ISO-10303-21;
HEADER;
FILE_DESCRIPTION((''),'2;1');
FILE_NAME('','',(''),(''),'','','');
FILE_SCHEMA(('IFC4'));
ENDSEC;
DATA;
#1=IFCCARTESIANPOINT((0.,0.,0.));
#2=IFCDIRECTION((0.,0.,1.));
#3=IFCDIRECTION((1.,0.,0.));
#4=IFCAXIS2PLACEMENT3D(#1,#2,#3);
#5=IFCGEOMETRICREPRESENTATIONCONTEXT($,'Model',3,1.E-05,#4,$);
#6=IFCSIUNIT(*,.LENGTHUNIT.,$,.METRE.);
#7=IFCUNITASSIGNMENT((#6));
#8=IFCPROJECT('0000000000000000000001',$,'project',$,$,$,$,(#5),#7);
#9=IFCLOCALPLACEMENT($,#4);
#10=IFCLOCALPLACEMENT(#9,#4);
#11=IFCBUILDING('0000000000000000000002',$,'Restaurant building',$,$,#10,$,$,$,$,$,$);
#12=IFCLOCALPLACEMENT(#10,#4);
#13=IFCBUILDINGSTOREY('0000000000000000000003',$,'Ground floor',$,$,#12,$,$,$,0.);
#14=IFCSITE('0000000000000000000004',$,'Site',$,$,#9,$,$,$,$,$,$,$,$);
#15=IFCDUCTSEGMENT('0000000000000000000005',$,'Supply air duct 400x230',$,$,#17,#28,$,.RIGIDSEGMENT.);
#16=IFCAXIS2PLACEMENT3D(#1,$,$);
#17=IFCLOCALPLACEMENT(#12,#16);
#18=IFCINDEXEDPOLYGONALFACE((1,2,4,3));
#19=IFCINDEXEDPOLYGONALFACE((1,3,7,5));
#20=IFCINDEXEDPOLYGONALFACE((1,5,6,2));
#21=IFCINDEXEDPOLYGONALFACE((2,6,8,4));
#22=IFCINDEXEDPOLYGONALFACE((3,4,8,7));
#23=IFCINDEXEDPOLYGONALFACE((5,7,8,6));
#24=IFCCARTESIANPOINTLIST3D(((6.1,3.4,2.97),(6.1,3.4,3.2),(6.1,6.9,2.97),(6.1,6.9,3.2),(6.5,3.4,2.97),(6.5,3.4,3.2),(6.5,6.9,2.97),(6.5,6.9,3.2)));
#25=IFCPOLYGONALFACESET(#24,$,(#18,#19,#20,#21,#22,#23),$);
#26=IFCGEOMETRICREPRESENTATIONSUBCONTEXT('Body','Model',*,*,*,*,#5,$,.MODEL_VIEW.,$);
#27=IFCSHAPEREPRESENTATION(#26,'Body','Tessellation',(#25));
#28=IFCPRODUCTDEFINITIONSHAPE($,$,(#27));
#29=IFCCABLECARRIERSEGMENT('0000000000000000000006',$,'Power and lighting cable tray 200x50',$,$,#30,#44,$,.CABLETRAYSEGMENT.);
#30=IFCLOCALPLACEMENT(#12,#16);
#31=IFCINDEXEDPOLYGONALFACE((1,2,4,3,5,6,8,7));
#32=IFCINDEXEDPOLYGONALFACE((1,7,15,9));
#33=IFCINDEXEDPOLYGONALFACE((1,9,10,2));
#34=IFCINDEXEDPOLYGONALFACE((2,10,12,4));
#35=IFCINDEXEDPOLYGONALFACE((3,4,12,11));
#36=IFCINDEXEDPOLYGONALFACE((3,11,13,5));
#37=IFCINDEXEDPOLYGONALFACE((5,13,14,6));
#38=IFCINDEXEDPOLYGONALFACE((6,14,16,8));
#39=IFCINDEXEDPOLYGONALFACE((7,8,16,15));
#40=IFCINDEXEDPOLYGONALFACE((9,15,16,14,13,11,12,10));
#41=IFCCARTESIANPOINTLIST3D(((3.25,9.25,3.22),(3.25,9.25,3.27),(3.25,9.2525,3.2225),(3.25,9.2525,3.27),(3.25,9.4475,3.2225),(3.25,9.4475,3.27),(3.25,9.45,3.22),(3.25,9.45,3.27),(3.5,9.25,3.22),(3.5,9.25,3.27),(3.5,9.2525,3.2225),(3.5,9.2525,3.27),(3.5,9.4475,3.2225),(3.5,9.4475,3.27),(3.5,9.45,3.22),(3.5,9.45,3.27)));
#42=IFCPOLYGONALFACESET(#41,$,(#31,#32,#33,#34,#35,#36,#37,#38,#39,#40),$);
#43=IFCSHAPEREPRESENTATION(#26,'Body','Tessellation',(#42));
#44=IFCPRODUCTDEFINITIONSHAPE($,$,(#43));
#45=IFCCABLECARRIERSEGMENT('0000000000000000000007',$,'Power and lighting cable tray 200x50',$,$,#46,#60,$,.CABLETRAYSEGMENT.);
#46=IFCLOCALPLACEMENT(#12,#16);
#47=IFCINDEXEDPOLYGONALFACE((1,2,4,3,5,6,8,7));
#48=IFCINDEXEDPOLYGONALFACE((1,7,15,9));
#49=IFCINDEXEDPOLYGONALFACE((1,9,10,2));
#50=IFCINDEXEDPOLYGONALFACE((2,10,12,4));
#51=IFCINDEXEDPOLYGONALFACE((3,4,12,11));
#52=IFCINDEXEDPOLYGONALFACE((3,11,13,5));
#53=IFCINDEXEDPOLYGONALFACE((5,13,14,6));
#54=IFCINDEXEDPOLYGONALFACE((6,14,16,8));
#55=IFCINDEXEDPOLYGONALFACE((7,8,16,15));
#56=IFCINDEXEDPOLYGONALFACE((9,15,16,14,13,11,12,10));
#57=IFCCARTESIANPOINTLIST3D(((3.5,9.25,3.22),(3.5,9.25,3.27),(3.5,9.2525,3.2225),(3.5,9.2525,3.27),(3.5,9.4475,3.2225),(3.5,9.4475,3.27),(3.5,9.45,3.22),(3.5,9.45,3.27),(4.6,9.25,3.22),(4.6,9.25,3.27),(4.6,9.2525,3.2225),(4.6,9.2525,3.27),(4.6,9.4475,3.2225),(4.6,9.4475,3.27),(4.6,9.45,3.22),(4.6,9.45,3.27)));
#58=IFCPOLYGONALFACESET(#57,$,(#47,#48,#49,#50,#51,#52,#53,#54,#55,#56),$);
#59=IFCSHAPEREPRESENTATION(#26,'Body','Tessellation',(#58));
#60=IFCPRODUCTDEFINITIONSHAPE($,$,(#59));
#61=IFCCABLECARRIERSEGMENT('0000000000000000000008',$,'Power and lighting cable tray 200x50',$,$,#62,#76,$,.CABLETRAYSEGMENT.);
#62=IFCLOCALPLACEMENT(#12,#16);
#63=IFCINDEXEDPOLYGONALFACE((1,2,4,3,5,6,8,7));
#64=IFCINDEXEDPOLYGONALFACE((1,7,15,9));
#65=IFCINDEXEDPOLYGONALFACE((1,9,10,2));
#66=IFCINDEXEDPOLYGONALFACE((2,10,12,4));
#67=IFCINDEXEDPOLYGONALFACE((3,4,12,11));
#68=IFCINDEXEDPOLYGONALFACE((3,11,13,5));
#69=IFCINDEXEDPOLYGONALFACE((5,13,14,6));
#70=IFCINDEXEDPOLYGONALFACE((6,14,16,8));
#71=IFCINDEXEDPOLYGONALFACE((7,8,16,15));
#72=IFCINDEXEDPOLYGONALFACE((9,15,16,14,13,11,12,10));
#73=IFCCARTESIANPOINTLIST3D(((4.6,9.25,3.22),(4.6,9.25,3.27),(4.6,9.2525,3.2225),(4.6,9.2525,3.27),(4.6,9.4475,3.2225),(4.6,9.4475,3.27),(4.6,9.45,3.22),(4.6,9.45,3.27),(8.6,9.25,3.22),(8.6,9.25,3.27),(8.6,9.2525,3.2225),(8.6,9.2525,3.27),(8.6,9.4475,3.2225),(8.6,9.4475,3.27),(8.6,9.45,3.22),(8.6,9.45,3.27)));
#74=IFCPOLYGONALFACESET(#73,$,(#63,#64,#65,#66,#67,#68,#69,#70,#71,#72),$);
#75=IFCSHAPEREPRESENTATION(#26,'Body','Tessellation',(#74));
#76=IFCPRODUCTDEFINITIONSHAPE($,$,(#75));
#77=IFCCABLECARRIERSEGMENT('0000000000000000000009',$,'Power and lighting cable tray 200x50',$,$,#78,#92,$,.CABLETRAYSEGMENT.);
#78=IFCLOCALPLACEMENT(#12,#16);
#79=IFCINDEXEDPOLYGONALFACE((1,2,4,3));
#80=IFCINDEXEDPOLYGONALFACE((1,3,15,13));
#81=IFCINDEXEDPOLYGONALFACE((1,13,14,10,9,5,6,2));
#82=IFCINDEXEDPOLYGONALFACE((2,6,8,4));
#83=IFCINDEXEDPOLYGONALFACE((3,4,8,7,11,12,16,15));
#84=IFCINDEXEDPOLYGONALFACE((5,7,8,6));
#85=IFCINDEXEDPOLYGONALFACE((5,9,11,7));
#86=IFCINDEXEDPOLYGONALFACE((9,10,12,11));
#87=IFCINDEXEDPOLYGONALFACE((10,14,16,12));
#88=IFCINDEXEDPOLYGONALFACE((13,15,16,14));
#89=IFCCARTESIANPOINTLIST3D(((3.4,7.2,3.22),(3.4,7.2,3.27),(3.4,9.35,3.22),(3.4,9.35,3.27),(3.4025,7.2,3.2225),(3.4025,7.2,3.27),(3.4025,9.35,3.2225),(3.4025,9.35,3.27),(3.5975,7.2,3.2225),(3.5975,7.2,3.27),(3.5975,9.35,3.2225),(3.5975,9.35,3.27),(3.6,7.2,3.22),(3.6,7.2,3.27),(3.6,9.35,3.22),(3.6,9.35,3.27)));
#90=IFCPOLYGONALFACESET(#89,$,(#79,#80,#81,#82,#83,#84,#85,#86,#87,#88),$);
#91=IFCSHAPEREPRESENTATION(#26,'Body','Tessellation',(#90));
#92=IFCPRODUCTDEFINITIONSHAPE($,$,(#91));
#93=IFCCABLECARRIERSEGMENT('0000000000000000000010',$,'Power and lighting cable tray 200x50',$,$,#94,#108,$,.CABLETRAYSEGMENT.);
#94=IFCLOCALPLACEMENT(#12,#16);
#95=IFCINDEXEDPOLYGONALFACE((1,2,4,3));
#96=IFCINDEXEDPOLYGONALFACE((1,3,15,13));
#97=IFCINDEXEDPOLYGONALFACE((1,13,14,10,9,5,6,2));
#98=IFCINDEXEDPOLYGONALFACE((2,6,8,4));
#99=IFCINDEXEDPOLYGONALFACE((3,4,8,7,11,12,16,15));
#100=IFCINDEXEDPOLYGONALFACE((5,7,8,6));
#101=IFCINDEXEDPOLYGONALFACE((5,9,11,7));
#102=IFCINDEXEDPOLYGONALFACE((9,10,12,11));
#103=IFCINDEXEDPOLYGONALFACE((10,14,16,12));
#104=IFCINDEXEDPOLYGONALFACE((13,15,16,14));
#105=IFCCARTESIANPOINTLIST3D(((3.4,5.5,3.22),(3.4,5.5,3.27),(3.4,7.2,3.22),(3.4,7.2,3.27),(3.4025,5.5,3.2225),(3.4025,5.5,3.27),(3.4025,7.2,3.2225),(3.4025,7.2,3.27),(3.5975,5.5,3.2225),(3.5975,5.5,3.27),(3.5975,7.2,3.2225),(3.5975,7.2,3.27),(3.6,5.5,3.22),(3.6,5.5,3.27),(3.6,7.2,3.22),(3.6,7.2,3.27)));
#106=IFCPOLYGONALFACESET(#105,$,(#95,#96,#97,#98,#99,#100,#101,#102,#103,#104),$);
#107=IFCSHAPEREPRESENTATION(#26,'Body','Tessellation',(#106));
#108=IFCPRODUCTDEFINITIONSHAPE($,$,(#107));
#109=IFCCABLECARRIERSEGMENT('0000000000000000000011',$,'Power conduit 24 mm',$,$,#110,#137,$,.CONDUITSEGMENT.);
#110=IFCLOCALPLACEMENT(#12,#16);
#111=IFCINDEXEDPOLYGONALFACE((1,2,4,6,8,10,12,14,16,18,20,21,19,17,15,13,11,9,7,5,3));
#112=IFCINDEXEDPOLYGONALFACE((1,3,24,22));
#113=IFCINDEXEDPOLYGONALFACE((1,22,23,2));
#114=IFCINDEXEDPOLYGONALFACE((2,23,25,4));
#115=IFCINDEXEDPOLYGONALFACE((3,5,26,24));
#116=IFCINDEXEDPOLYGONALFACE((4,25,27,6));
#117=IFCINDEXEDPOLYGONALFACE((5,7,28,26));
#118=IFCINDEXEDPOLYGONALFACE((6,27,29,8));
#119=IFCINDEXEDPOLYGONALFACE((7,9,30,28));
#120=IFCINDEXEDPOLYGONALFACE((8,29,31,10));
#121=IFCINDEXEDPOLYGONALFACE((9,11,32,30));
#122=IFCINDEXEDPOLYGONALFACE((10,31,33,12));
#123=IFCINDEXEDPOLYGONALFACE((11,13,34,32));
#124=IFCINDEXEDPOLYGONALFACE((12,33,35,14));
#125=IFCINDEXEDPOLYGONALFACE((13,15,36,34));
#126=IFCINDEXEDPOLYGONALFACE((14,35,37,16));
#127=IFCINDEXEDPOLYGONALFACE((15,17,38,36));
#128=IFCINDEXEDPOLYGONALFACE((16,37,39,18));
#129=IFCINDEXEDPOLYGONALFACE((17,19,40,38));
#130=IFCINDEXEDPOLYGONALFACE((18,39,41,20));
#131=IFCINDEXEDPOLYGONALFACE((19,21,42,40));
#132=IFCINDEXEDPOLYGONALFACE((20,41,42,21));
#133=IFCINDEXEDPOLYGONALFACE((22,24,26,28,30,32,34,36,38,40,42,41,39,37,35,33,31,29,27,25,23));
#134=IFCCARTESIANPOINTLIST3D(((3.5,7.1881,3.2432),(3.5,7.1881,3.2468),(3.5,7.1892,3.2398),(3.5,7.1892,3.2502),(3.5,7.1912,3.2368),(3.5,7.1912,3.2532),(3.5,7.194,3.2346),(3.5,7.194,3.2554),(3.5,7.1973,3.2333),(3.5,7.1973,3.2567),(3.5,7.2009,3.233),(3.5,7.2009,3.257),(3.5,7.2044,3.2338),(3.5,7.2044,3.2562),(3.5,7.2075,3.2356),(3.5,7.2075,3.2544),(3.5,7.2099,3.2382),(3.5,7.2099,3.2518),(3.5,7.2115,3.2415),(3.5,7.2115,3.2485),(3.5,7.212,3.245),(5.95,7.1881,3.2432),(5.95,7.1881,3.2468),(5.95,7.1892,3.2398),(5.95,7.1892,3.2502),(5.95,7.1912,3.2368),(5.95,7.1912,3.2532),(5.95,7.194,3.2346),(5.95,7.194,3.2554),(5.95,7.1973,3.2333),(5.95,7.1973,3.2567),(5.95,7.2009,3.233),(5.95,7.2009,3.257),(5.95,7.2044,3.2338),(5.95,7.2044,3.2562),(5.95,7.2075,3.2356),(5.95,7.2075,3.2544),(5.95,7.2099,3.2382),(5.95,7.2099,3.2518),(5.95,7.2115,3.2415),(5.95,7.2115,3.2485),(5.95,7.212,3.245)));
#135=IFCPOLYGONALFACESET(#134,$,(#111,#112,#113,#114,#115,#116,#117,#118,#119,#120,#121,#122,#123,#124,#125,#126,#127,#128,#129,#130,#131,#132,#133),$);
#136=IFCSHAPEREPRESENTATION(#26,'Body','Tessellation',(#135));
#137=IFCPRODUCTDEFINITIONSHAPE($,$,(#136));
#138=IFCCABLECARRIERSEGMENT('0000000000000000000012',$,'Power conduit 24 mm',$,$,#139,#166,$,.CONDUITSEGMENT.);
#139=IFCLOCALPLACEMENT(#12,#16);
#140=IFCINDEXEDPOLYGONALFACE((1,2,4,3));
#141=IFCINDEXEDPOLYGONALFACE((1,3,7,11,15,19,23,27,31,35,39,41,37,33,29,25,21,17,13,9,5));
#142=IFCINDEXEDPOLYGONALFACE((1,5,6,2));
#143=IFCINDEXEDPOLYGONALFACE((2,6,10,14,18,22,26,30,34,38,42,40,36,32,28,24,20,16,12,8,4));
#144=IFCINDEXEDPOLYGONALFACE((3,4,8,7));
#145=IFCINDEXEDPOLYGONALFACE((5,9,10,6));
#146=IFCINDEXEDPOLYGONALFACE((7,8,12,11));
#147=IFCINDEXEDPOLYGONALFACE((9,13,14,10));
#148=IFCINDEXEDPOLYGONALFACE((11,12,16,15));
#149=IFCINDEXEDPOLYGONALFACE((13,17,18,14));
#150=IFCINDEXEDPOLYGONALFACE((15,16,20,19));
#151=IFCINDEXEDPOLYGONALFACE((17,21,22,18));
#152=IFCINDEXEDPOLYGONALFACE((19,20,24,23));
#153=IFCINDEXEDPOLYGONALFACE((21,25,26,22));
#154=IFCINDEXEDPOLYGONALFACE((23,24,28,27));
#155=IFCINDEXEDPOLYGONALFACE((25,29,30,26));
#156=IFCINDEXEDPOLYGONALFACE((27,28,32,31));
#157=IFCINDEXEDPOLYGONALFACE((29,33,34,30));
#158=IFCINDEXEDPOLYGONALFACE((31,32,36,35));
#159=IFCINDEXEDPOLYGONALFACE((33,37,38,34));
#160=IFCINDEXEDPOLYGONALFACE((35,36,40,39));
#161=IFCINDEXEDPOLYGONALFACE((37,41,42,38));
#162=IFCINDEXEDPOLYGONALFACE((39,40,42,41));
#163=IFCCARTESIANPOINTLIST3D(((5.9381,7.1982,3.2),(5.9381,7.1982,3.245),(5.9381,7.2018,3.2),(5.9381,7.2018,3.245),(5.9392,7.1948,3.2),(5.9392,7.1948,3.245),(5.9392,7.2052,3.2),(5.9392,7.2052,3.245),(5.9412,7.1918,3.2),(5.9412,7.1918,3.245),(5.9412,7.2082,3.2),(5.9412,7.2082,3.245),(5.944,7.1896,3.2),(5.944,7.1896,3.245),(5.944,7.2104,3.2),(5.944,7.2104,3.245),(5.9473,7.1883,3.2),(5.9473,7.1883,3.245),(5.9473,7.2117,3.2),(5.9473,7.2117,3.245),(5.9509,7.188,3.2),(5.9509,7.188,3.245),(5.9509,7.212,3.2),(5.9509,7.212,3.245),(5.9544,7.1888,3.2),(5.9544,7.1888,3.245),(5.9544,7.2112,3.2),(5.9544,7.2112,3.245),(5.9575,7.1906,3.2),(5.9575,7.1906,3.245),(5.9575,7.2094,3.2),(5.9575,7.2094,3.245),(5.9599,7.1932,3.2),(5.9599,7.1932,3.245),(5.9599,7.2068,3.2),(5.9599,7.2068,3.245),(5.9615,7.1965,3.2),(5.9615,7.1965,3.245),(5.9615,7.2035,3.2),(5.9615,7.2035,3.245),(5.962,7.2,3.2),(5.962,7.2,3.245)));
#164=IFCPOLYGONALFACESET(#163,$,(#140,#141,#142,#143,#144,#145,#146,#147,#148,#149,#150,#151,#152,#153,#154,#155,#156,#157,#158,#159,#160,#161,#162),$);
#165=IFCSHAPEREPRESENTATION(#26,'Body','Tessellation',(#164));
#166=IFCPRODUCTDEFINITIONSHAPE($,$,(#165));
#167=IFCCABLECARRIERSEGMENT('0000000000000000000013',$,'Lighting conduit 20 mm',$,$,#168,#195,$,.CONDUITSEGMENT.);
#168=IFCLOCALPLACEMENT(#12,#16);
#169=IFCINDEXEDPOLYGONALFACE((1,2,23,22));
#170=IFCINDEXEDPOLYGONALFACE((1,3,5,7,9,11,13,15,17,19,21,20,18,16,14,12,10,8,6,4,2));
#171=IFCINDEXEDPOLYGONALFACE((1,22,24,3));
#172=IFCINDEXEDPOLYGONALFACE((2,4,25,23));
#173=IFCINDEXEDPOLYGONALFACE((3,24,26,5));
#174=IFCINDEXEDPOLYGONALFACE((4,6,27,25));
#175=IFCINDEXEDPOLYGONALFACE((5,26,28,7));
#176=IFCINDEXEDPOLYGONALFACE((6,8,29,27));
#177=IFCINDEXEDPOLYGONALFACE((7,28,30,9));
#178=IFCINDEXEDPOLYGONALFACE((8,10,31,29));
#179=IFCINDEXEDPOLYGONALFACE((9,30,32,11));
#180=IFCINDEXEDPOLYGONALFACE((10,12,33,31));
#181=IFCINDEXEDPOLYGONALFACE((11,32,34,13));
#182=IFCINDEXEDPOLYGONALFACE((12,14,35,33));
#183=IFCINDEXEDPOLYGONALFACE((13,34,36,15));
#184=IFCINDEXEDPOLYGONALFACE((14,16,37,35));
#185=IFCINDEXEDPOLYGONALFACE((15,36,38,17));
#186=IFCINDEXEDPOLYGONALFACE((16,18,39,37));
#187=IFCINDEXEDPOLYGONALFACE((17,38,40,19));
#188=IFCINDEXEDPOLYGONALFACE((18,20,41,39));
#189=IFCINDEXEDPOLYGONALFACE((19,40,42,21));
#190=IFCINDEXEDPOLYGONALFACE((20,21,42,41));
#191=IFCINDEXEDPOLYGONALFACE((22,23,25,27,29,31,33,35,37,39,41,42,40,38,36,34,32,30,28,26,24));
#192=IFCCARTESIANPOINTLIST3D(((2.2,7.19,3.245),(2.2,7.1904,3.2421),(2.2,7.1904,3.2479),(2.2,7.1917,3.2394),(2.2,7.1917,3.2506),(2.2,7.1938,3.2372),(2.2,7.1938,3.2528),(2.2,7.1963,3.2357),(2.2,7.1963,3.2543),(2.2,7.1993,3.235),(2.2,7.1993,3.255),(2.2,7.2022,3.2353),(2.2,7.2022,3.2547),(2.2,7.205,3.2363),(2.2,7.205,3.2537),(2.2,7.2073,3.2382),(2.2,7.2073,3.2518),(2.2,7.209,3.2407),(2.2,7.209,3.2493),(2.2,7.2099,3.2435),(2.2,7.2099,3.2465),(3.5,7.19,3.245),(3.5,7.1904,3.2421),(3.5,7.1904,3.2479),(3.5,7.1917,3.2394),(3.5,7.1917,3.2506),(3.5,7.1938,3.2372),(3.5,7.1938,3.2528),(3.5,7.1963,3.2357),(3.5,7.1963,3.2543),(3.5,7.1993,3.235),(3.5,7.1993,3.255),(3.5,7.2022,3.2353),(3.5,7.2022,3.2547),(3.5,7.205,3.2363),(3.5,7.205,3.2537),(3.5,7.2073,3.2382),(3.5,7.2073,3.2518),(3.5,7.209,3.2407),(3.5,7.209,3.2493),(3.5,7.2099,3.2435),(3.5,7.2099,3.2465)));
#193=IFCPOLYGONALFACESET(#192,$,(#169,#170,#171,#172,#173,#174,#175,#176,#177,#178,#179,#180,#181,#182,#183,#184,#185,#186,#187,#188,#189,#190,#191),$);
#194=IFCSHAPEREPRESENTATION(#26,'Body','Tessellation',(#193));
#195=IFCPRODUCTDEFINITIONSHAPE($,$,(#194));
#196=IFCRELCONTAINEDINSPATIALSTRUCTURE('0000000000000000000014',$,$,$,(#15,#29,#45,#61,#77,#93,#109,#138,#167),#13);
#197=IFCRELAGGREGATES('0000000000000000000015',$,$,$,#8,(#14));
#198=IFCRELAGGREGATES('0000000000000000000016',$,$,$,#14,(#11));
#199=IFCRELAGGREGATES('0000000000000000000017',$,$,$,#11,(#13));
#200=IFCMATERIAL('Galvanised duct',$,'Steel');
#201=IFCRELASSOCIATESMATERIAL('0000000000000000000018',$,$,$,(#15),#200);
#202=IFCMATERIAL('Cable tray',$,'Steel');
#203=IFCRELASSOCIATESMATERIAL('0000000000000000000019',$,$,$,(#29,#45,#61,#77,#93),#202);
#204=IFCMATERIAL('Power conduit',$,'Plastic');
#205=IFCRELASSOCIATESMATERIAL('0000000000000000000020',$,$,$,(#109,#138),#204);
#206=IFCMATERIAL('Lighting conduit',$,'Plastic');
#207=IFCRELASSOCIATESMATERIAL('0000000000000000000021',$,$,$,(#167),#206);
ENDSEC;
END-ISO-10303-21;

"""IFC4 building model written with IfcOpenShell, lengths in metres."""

from ifc_helpers import new_model, si_unit, frame, origin_with_axes, origin_2d, place, context, subcontext, project, spatial, polyline, rectangle, circle, outline, extrude, material, element, save


model = new_model("IFC4")

# Units and contexts
model_context = context("Model", 3, precision=1e-05, world=origin_with_axes())
body_context = subcontext(model_context, "Body", "Model", "MODEL_VIEW")
ifc_project = project(units=[si_unit("LENGTHUNIT", "METRE")], contexts=[model_context])

# Site, building, storey
site_placement = place(None, origin_with_axes())
site = spatial("IfcSite", under=ifc_project, at=site_placement, Name="Site")
building_placement = place(site_placement, origin_with_axes())
building = spatial("IfcBuilding", under=site, at=building_placement, Name="Restaurant building")
storey_placement = place(building_placement, origin_with_axes())
storey = spatial("IfcBuildingStorey", under=building, at=storey_placement, Name="Ground floor", Elevation=0.0)

# Duct segment
ifc_material_1 = material(Name="Galvanised duct", Category="Steel")
duct_segment_placement = place(storey_placement, frame((6.3, 6.9, 3.085)))
element("IfcDuctSegment", 1, at=duct_segment_placement, inside=storey, material=ifc_material_1, Name="Supply air duct 400x230", PredefinedType="RIGIDSEGMENT", context=body_context, shape_type="SweptSolid", body=[
    extrude(rectangle(XDim=0.4, YDim=0.23, at=origin_2d()), frame((0.0, 0.0, 0.0), z_axis=(0.0, -1.0, 0.0), x_axis=(1.0, 0.0, 0.0)), (0.0, 0.0, 1.0), 3.5),
])

# Cable carrier segments
ifc_material_2 = material(Name="Cable tray", Category="Steel")
cable_carrier_segment_1_placement = place(storey_placement, frame((3.25, 9.35, 3.245)))
element("IfcCableCarrierSegment", 2, at=cable_carrier_segment_1_placement, inside=storey, material=ifc_material_2, Name="Power and lighting cable tray 200x50", PredefinedType="CABLETRAYSEGMENT", context=body_context, shape_type="SweptSolid", body=[
    extrude(outline(polyline([(-0.1, -0.025), (0.1, -0.025), (0.1, 0.025), (0.0975, 0.025), (0.0975, -0.0225), (-0.0975, -0.0225), (-0.0975, 0.025), (-0.1, 0.025), (-0.1, -0.025)])), frame((0.0, 0.0, 0.0), z_axis=(1.0, 0.0, 0.0), x_axis=(0.0, 1.0, 0.0)), (0.0, 0.0, 1.0), 0.25),
])
cable_carrier_segment_2_placement = place(storey_placement, frame((3.5, 9.35, 3.245)))
element("IfcCableCarrierSegment", 3, at=cable_carrier_segment_2_placement, inside=storey, material=ifc_material_2, Name="Power and lighting cable tray 200x50", PredefinedType="CABLETRAYSEGMENT", context=body_context, shape_type="SweptSolid", body=[
    extrude(outline(polyline([(-0.1, -0.025), (0.1, -0.025), (0.1, 0.025), (0.0975, 0.025), (0.0975, -0.0225), (-0.0975, -0.0225), (-0.0975, 0.025), (-0.1, 0.025), (-0.1, -0.025)])), frame((0.0, 0.0, 0.0), z_axis=(1.0, 0.0, 0.0), x_axis=(0.0, 1.0, 0.0)), (0.0, 0.0, 1.0), 1.1),
])
cable_carrier_segment_3_placement = place(storey_placement, frame((4.6, 9.35, 3.245)))
element("IfcCableCarrierSegment", 4, at=cable_carrier_segment_3_placement, inside=storey, material=ifc_material_2, Name="Power and lighting cable tray 200x50", PredefinedType="CABLETRAYSEGMENT", context=body_context, shape_type="SweptSolid", body=[
    extrude(outline(polyline([(-0.1, -0.025), (0.1, -0.025), (0.1, 0.025), (0.0975, 0.025), (0.0975, -0.0225), (-0.0975, -0.0225), (-0.0975, 0.025), (-0.1, 0.025), (-0.1, -0.025)])), frame((0.0, 0.0, 0.0), z_axis=(1.0, 0.0, 0.0), x_axis=(0.0, 1.0, 0.0)), (0.0, 0.0, 1.0), 4.0),
])
cable_carrier_segment_4_placement = place(storey_placement, frame((3.5, 9.35, 3.245)))
element("IfcCableCarrierSegment", 5, at=cable_carrier_segment_4_placement, inside=storey, material=ifc_material_2, Name="Power and lighting cable tray 200x50", PredefinedType="CABLETRAYSEGMENT", context=body_context, shape_type="SweptSolid", body=[
    extrude(outline(polyline([(-0.1, -0.025), (0.1, -0.025), (0.1, 0.025), (0.0975, 0.025), (0.0975, -0.0225), (-0.0975, -0.0225), (-0.0975, 0.025), (-0.1, 0.025), (-0.1, -0.025)])), frame((0.0, 0.0, 0.0), z_axis=(0.0, -1.0, 0.0), x_axis=(1.0, 0.0, 0.0)), (0.0, 0.0, 1.0), 2.15),
])
cable_carrier_segment_5_placement = place(storey_placement, frame((3.5, 7.2, 3.245)))
element("IfcCableCarrierSegment", 6, at=cable_carrier_segment_5_placement, inside=storey, material=ifc_material_2, Name="Power and lighting cable tray 200x50", PredefinedType="CABLETRAYSEGMENT", context=body_context, shape_type="SweptSolid", body=[
    extrude(outline(polyline([(-0.1, -0.025), (0.1, -0.025), (0.1, 0.025), (0.0975, 0.025), (0.0975, -0.0225), (-0.0975, -0.0225), (-0.0975, 0.025), (-0.1, 0.025), (-0.1, -0.025)])), frame((0.0, 0.0, 0.0), z_axis=(0.0, -1.0, 0.0), x_axis=(1.0, 0.0, 0.0)), (0.0, 0.0, 1.0), 1.7),
])
ifc_material_3 = material(Name="Power conduit", Category="Plastic")
cable_carrier_segment_6_placement = place(storey_placement, frame((3.5, 7.2, 3.245)))
element("IfcCableCarrierSegment", 7, at=cable_carrier_segment_6_placement, inside=storey, material=ifc_material_3, Name="Power conduit 24 mm", PredefinedType="CONDUITSEGMENT", context=body_context, shape_type="SweptSolid", body=[
    extrude(circle(Radius=0.012, at=origin_2d()), frame((0.0, 0.0, 0.0), z_axis=(1.0, 0.0, 0.0), x_axis=(0.0, 1.0, 0.0)), (0.0, 0.0, 1.0), 2.45),
])
cable_carrier_segment_7_placement = place(storey_placement, frame((5.95, 7.2, 3.245)))
element("IfcCableCarrierSegment", 8, at=cable_carrier_segment_7_placement, inside=storey, material=ifc_material_3, Name="Power conduit 24 mm", PredefinedType="CONDUITSEGMENT", context=body_context, shape_type="SweptSolid", body=[
    extrude(circle(Radius=0.012, at=origin_2d()), frame((0.0, 0.0, 0.0), z_axis=(0.0, 0.0, -1.0), x_axis=(1.0, 0.0, 0.0)), (0.0, 0.0, 1.0), 0.045),
])
ifc_material_4 = material(Name="Lighting conduit", Category="Plastic")
cable_carrier_segment_8_placement = place(storey_placement, frame((3.5, 7.2, 3.245)))
element("IfcCableCarrierSegment", 9, at=cable_carrier_segment_8_placement, inside=storey, material=ifc_material_4, Name="Lighting conduit 20 mm", PredefinedType="CONDUITSEGMENT", context=body_context, shape_type="SweptSolid", body=[
    extrude(circle(Radius=0.01, at=origin_2d()), frame((0.0, 0.0, 0.0), z_axis=(-1.0, 0.0, 0.0), x_axis=(0.0, -1.0, 0.0)), (0.0, 0.0, 1.0), 1.3),
])

save(model, "model.ifc")
